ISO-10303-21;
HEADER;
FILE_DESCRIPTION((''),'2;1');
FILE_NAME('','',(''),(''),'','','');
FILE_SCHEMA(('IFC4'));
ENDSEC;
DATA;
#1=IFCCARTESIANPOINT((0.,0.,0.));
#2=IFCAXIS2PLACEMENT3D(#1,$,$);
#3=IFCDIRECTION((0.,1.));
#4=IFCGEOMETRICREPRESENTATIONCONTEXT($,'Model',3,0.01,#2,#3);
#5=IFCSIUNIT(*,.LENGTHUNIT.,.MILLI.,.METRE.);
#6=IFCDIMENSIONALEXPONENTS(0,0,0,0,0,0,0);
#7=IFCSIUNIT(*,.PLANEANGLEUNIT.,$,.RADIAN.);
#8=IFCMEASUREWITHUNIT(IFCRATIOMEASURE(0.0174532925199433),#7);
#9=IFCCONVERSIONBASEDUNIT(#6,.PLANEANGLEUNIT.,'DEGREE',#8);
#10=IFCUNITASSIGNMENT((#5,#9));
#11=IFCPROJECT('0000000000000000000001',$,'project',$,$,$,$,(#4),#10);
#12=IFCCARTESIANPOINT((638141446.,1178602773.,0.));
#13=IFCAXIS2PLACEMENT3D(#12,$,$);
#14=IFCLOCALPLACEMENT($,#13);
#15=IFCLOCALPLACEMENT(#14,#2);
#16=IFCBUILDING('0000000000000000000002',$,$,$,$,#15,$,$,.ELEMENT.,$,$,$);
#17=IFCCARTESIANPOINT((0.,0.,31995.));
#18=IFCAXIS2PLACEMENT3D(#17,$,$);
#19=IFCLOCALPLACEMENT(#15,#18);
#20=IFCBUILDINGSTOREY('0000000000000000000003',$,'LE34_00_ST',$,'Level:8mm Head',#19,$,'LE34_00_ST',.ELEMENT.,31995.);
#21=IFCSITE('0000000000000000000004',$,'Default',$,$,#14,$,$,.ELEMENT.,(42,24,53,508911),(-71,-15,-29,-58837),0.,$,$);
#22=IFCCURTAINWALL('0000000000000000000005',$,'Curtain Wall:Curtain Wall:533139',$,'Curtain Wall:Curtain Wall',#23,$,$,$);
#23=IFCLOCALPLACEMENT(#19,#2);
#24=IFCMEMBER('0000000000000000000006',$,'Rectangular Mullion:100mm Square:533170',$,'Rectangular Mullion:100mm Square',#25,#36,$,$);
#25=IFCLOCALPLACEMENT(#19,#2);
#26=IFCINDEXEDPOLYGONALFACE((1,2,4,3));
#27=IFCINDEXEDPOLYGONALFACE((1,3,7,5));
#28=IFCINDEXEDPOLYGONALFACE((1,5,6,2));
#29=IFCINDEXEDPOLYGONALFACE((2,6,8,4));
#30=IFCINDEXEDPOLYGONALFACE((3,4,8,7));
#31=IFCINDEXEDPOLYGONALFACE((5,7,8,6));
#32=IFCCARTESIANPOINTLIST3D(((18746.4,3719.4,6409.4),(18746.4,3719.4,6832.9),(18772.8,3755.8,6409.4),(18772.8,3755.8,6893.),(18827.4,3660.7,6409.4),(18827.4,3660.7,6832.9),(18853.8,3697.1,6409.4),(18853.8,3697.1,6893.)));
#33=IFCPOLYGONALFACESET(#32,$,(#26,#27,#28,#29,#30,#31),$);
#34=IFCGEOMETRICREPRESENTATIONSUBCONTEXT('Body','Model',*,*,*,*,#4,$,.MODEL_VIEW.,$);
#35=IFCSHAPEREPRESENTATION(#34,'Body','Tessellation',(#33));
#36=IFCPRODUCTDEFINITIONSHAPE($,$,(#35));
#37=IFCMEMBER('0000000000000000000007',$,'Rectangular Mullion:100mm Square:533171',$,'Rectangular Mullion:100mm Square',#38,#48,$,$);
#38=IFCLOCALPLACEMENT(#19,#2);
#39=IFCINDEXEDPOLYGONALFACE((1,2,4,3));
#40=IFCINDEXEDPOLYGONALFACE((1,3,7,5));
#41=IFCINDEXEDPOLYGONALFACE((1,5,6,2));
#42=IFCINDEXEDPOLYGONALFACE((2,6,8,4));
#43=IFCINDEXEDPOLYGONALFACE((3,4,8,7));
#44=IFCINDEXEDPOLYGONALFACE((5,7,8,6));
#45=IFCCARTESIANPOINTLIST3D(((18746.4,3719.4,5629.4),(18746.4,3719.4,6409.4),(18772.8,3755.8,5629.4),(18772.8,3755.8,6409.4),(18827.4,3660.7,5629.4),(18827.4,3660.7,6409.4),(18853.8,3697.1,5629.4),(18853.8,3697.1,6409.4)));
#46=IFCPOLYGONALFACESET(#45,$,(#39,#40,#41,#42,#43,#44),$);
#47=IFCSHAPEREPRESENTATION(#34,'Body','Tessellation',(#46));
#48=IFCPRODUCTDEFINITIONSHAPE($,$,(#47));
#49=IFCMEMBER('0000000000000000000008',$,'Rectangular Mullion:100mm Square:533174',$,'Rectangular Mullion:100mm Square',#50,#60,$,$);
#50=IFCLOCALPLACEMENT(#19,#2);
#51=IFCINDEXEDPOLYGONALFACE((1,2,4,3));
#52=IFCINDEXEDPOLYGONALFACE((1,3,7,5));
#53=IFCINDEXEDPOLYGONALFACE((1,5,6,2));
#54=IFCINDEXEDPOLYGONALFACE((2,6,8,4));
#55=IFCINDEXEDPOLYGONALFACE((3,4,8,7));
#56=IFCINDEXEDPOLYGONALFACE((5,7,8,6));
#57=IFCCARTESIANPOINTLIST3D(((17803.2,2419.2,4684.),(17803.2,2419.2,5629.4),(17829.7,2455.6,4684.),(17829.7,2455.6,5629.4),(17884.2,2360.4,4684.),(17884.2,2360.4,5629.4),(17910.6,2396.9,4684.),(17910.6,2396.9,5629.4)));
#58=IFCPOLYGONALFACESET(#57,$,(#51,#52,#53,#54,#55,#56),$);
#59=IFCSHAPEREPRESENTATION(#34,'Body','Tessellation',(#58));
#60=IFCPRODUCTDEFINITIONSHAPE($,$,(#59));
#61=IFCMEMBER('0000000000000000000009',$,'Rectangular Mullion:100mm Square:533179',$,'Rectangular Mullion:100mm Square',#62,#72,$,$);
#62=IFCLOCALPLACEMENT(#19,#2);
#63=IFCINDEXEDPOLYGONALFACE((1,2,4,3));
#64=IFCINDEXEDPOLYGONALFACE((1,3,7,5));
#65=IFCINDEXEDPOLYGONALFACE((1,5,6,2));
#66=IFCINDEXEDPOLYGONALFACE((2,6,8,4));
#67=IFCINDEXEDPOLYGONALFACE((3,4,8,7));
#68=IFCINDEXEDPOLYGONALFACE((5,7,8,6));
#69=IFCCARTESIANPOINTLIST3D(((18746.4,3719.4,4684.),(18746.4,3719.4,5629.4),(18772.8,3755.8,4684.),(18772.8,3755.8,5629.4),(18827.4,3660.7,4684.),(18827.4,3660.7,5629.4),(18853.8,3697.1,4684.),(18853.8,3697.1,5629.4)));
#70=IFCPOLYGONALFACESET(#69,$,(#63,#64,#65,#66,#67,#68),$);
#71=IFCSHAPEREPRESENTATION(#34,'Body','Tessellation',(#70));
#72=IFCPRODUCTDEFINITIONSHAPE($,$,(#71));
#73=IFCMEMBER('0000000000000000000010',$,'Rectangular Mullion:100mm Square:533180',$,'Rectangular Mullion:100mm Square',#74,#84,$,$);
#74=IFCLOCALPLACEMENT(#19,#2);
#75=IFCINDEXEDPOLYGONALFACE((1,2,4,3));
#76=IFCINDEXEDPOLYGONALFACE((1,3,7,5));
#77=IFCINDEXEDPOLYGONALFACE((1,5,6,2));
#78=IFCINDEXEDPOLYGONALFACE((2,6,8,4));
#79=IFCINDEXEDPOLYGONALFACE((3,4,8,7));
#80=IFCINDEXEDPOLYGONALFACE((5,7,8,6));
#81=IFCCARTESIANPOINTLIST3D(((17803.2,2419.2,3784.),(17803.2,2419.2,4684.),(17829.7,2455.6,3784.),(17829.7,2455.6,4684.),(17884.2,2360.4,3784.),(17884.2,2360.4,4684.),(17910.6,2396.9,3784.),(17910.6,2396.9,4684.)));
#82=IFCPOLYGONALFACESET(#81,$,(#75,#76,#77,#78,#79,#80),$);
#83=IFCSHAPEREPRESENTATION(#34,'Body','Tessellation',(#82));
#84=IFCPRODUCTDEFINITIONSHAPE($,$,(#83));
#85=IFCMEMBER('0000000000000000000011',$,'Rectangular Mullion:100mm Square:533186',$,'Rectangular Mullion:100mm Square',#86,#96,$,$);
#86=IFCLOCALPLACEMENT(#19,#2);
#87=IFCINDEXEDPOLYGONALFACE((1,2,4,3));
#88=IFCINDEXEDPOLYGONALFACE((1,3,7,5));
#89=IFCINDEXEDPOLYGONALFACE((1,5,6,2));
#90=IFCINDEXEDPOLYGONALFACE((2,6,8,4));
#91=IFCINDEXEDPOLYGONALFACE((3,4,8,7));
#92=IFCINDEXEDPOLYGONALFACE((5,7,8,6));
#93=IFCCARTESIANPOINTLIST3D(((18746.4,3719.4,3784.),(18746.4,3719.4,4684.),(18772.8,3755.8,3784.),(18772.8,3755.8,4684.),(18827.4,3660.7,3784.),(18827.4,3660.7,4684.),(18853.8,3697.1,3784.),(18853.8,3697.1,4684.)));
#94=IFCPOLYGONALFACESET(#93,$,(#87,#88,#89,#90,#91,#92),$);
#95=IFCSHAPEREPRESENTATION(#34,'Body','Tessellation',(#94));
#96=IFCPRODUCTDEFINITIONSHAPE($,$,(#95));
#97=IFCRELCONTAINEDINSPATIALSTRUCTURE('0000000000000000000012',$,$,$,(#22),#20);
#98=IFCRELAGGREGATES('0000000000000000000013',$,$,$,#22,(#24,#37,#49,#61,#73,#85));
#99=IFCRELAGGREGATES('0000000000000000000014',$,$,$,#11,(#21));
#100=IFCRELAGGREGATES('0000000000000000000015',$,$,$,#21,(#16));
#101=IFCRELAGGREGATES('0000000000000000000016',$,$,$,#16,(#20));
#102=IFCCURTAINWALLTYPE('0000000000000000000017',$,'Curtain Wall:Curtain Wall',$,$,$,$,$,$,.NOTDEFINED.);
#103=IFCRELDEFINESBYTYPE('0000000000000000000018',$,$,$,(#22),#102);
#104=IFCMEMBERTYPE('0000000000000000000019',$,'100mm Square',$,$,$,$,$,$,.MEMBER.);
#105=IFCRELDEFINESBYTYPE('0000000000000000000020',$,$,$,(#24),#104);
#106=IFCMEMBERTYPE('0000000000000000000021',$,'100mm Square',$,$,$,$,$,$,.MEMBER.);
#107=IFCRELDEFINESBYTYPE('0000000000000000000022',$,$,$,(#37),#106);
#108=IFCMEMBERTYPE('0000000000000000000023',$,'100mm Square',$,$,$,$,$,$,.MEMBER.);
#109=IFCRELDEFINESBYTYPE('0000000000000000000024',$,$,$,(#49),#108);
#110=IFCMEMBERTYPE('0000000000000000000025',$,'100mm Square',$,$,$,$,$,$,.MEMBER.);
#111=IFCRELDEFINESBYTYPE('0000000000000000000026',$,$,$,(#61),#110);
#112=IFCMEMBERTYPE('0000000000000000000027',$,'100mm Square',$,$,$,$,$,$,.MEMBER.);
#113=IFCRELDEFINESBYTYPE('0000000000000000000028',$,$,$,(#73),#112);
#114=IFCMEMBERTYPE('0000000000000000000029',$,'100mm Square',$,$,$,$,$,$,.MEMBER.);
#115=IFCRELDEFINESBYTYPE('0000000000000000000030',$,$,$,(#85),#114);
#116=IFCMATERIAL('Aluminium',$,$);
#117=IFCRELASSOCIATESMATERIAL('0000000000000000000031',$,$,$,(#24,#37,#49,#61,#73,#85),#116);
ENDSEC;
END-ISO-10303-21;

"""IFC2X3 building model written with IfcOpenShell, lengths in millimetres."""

from ifc_helpers import new_model, entity, si_unit, converted_unit, direction, frame, origin, origin_2d_with_axis, place, context, subcontext, project, spatial, rectangle, extrude, clip, halfspace, source, transform, mapped, material, type_object, type_shapes, element, aggregate, save


model = new_model("IFC2X3")

# Units and contexts
model_context = context("Model", 3, precision=0.01, world=origin(), true_north=direction((0.0, 1.0)))
body_context = subcontext(model_context, "Body", "Model", "MODEL_VIEW")
ifc_project = project(units=[si_unit("LENGTHUNIT", "METRE", prefix="MILLI"), converted_unit("PLANEANGLEUNIT", "DEGREE", entity("IfcRatioMeasure", 0.0174532925199433), si_unit("PLANEANGLEUNIT", "RADIAN"), dimensions=[0, 0, 0, 0, 0, 0, 0])], contexts=[model_context])

# Site, building, storey
site_placement = place(None, frame((638141446.0, 1178602773.0, 0.0)))
site = spatial("IfcSite", under=ifc_project, at=site_placement, Name="Default", CompositionType="ELEMENT", RefLatitude=(42, 24, 53, 508911), RefLongitude=(-71, -15, -29, -58837), RefElevation=0.0)
building_placement = place(site_placement, origin())
building = spatial("IfcBuilding", under=site, at=building_placement, CompositionType="ELEMENT")
storey_placement = place(building_placement, frame((0.0, 0.0, 31995.0)))
storey = spatial("IfcBuildingStorey", under=building, at=storey_placement, Name="LE34_00_ST", ObjectType="Level:8mm Head", LongName="LE34_00_ST", CompositionType="ELEMENT", Elevation=31995.0)

# Shared definitions
curtain_wall_type = type_object("IfcCurtainWallType", Name="Curtain Wall:Curtain Wall", PredefinedType="NOTDEFINED")
ifc_material_1 = material(Name="Aluminium")

# Curtain wall, members
curtain_wall_1_placement = place(storey_placement, frame((0.0, 0.0, -31995.0)))
curtain_wall_1 = element("IfcCurtainWall", 1, at=curtain_wall_1_placement, inside=storey, type_object=curtain_wall_type, Name="Curtain Wall:Curtain Wall:533139", ObjectType="Curtain Wall:Curtain Wall")
member_type_1 = type_object("IfcMemberType", Name="100mm Square", PredefinedType="MEMBER")
shared_shape_1 = source(origin(), body_context, "Body", "Clipping", [
    clip(extrude(rectangle(XDim=100.0, YDim=45.0, at=origin_2d_with_axis()), frame((-22.5, 0.0, -483.6), z_axis=(0.0, 0.0, 1.0), x_axis=(0.0, -1.0, 0.0)), (0.0, 0.0, 1.0), 483.6), halfspace(frame((0.0, -304.8, -483.6), z_axis=(-0.800333, 0.0, -0.599555), x_axis=(-0.599555, 0.0, 0.800333)), False)),
])
type_shapes(member_type_1, [shared_shape_1])
member_1_placement = place(storey_placement, frame((18813.3, 3726.5, 6409.4), z_axis=(0.0, 0.0, -1.0), x_axis=(0.587164, 0.809468, 0.0)))
member_1 = element("IfcMember", 2, at=member_1_placement, type_object=member_type_1, material=ifc_material_1, Name="Rectangular Mullion:100mm Square:533170", ObjectType="Rectangular Mullion:100mm Square", context=body_context, shape_type="MappedRepresentation", body=[
    mapped(shared_shape_1, transform((0.0, 0.0, 0.0), scale=1.0)),
])
member_type_2 = type_object("IfcMemberType", Name="100mm Square", PredefinedType="MEMBER")
shared_shape_2 = source(origin(), body_context, "Body", "SweptSolid", [
    extrude(rectangle(XDim=100.0, YDim=45.0, at=origin_2d_with_axis()), frame((-22.5, 0.0, -780.0), z_axis=(0.0, 0.0, 1.0), x_axis=(0.0, -1.0, 0.0)), (0.0, 0.0, 1.0), 780.0),
])
type_shapes(member_type_2, [shared_shape_2])
member_2_placement = place(storey_placement, frame((18813.3, 3726.5, 5629.4), z_axis=(0.0, 0.0, -1.0), x_axis=(0.587164, 0.809468, 0.0)))
member_2 = element("IfcMember", 3, at=member_2_placement, type_object=member_type_2, material=ifc_material_1, Name="Rectangular Mullion:100mm Square:533171", ObjectType="Rectangular Mullion:100mm Square", context=body_context, shape_type="MappedRepresentation", body=[
    mapped(shared_shape_2, transform((0.0, 0.0, 0.0), scale=1.0)),
])
member_type_3 = type_object("IfcMemberType", Name="100mm Square", PredefinedType="MEMBER")
shared_shape_3 = source(origin(), body_context, "Body", "SweptSolid", [
    extrude(rectangle(XDim=100.0, YDim=45.0, at=origin_2d_with_axis()), frame((-22.5, 0.0, -945.4), z_axis=(0.0, 0.0, 1.0), x_axis=(0.0, -1.0, 0.0)), (0.0, 0.0, 1.0), 945.4),
])
type_shapes(member_type_3, [shared_shape_3])
member_3_placement = place(storey_placement, frame((17843.7, 2389.8, 5629.4), z_axis=(0.0, 0.0, 1.0), x_axis=(-0.587164, -0.809468, 0.0)))
member_3 = element("IfcMember", 4, at=member_3_placement, type_object=member_type_3, material=ifc_material_1, Name="Rectangular Mullion:100mm Square:533174", ObjectType="Rectangular Mullion:100mm Square", context=body_context, shape_type="MappedRepresentation", body=[
    mapped(shared_shape_3, transform((0.0, 0.0, 0.0), scale=1.0)),
])
member_type_4 = type_object("IfcMemberType", Name="100mm Square", PredefinedType="MEMBER")
shared_shape_4 = source(origin(), body_context, "Body", "SweptSolid", [
    extrude(rectangle(XDim=100.0, YDim=45.0, at=origin_2d_with_axis()), frame((-22.5, 0.0, -945.4), z_axis=(0.0, 0.0, 1.0), x_axis=(0.0, -1.0, 0.0)), (0.0, 0.0, 1.0), 945.4),
])
type_shapes(member_type_4, [shared_shape_4])
member_4_placement = place(storey_placement, frame((18813.3, 3726.5, 4684.0), z_axis=(0.0, 0.0, -1.0), x_axis=(0.587164, 0.809468, 0.0)))
member_4 = element("IfcMember", 5, at=member_4_placement, type_object=member_type_4, material=ifc_material_1, Name="Rectangular Mullion:100mm Square:533179", ObjectType="Rectangular Mullion:100mm Square", context=body_context, shape_type="MappedRepresentation", body=[
    mapped(shared_shape_4, transform((0.0, 0.0, 0.0), scale=1.0)),
])
member_type_5 = type_object("IfcMemberType", Name="100mm Square", PredefinedType="MEMBER")
shared_shape_5 = source(origin(), body_context, "Body", "SweptSolid", [
    extrude(rectangle(XDim=100.0, YDim=45.0, at=origin_2d_with_axis()), frame((-22.5, 0.0, -900.0), z_axis=(0.0, 0.0, 1.0), x_axis=(0.0, -1.0, 0.0)), (0.0, 0.0, 1.0), 900.0),
])
type_shapes(member_type_5, [shared_shape_5])
member_5_placement = place(storey_placement, frame((17843.7, 2389.8, 4684.0), z_axis=(0.0, 0.0, 1.0), x_axis=(-0.587164, -0.809468, 0.0)))
member_5 = element("IfcMember", 6, at=member_5_placement, type_object=member_type_5, material=ifc_material_1, Name="Rectangular Mullion:100mm Square:533180", ObjectType="Rectangular Mullion:100mm Square", context=body_context, shape_type="MappedRepresentation", body=[
    mapped(shared_shape_5, transform((0.0, 0.0, 0.0), scale=1.0)),
])
member_type_6 = type_object("IfcMemberType", Name="100mm Square", PredefinedType="MEMBER")
shared_shape_6 = source(origin(), body_context, "Body", "SweptSolid", [
    extrude(rectangle(XDim=100.0, YDim=45.0, at=origin_2d_with_axis()), frame((-22.5, 0.0, -900.0), z_axis=(0.0, 0.0, 1.0), x_axis=(0.0, -1.0, 0.0)), (0.0, 0.0, 1.0), 900.0),
])
type_shapes(member_type_6, [shared_shape_6])
member_6_placement = place(storey_placement, frame((18813.3, 3726.5, 3784.0), z_axis=(0.0, 0.0, -1.0), x_axis=(0.587164, 0.809468, 0.0)))
member_6 = element("IfcMember", 7, at=member_6_placement, type_object=member_type_6, material=ifc_material_1, Name="Rectangular Mullion:100mm Square:533186", ObjectType="Rectangular Mullion:100mm Square", context=body_context, shape_type="MappedRepresentation", body=[
    mapped(shared_shape_6, transform((0.0, 0.0, 0.0), scale=1.0)),
])

aggregate(curtain_wall_1, [member_1, member_2, member_3, member_4, member_5, member_6])

save(model, "model.ifc")
